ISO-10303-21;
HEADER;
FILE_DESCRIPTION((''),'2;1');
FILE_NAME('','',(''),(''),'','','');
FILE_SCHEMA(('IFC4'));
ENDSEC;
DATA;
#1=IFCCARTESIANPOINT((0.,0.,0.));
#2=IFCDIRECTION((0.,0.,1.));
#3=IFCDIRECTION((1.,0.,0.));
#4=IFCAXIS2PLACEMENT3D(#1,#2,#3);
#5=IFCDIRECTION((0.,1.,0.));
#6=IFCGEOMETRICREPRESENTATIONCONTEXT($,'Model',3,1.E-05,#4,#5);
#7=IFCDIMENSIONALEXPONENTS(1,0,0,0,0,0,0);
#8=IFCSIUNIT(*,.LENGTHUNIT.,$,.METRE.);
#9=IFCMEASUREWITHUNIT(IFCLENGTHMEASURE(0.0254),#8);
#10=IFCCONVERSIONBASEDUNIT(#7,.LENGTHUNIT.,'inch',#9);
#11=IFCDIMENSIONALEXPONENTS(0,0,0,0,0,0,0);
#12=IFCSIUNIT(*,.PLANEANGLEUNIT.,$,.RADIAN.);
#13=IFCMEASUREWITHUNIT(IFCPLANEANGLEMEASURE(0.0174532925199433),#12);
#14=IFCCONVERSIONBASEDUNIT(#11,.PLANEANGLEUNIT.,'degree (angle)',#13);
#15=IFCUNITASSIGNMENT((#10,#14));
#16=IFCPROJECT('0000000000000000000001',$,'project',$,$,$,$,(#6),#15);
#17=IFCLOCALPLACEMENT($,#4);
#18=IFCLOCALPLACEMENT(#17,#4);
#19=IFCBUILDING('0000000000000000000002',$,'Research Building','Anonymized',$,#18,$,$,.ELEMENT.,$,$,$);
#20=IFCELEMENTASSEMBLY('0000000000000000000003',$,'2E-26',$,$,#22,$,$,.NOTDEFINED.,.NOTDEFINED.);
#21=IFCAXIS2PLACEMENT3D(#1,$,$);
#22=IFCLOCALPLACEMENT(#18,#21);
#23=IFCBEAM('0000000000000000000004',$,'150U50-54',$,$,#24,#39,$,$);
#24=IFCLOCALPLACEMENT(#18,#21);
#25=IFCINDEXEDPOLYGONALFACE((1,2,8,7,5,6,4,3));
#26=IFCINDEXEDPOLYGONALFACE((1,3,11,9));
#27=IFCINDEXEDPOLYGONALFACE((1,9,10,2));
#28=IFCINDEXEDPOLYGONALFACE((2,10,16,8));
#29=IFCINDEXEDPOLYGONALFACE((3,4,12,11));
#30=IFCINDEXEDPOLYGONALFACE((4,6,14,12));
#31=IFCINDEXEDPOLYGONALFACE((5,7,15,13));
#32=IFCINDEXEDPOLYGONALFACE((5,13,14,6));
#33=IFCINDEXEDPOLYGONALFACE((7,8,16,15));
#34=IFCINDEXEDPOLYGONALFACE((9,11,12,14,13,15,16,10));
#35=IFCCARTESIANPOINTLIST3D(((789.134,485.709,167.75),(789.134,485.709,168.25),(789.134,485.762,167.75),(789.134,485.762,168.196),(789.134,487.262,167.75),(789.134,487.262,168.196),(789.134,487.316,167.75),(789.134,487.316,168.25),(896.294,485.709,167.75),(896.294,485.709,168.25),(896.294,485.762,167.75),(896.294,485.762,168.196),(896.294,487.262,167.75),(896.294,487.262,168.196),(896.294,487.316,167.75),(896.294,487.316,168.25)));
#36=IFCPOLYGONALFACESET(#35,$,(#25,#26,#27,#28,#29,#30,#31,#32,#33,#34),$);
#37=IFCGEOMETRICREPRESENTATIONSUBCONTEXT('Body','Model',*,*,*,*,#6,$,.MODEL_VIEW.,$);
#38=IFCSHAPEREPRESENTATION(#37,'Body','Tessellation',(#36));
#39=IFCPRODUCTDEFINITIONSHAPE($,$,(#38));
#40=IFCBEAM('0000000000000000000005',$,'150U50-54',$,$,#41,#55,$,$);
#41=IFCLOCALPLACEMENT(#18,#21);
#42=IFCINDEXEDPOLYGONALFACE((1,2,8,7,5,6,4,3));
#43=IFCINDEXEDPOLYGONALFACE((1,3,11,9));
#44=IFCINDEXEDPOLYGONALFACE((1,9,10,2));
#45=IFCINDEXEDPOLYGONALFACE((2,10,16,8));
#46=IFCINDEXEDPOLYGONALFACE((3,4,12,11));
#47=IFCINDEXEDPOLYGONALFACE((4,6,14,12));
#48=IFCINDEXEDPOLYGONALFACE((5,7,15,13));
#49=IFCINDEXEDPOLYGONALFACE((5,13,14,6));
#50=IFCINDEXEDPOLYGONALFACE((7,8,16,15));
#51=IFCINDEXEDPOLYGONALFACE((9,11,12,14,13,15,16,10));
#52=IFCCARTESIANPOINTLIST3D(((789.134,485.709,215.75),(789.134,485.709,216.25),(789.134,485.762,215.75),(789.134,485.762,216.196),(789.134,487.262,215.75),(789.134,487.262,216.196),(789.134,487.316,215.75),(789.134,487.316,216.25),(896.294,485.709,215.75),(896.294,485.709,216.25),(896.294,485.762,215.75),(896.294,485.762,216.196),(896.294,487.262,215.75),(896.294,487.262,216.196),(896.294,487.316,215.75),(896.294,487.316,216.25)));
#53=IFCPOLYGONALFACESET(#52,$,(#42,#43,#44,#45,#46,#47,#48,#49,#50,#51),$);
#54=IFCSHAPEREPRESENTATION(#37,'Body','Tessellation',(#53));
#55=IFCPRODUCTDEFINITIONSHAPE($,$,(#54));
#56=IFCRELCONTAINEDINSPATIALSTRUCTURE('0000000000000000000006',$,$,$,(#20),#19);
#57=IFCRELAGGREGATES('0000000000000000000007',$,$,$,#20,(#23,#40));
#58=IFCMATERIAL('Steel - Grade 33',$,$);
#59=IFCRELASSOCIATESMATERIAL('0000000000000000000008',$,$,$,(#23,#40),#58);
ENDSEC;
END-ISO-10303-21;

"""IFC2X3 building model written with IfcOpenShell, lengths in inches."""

from ifc_helpers import new_model, entity, si_unit, converted_unit, direction, frame, origin_with_axes, place, context, subcontext, project, spatial, polyline, segment, composite_curve, outline, extrude, material, element, aggregate, save


model = new_model("IFC2X3")

# Units and contexts
model_context = context("Model", 3, precision=1e-05, world=origin_with_axes(), true_north=direction((0.0, 1.0, 0.0)))
body_context = subcontext(model_context, "Body", "Model", "MODEL_VIEW")
ifc_project = project(units=[converted_unit("LENGTHUNIT", "inch", entity("IfcLengthMeasure", 0.0254), si_unit("LENGTHUNIT", "METRE"), dimensions=[1, 0, 0, 0, 0, 0, 0]), converted_unit("PLANEANGLEUNIT", "degree (angle)", entity("IfcPlaneAngleMeasure", 0.0174532925199433), si_unit("PLANEANGLEUNIT", "RADIAN"), dimensions=[0, 0, 0, 0, 0, 0, 0])], contexts=[model_context])

# Building
placement = place(None, origin_with_axes())
building_placement = place(placement, origin_with_axes())
building = spatial("IfcBuilding", at=building_placement, Name="Research Building", Description="Anonymized", CompositionType="ELEMENT")

# Element assembly, beams
assembly_placement = place(building_placement, origin_with_axes())
assembly = element("IfcElementAssembly", 1, at=assembly_placement, inside=building, Name="2E-26", AssemblyPlace="NOTDEFINED", PredefinedType="NOTDEFINED")
ifc_material = material(Name="Steel - Grade 33")
beam_1_placement = place(assembly_placement, frame((789.134, 486.512, 168.0), z_axis=(1.0, 0.0, 0.0), x_axis=(0.0, 0.0, -1.0)))
beam_1 = element("IfcBeam", 2, at=beam_1_placement, material=ifc_material, Name="150U50-54", context=body_context, shape_type="SweptSolid", body=[
    extrude(outline(composite_curve([segment(polyline([(-0.25, -0.804), (-0.25, 0.804), (0.25, 0.804), (0.25, 0.75), (-0.196, 0.75), (-0.196, -0.75), (0.25, -0.75), (0.25, -0.804), (-0.25, -0.804)]), True, "CONTINUOUS")], self_intersect=False)), origin_with_axes(), (0.0, 0.0, 1.0), 107.16),
])
beam_2_placement = place(assembly_placement, frame((789.134, 486.512, 216.0), z_axis=(1.0, 0.0, 0.0), x_axis=(0.0, 0.0, -1.0)))
beam_2 = element("IfcBeam", 3, at=beam_2_placement, material=ifc_material, Name="150U50-54", context=body_context, shape_type="SweptSolid", body=[
    extrude(outline(composite_curve([segment(polyline([(-0.25, -0.804), (-0.25, 0.804), (0.25, 0.804), (0.25, 0.75), (-0.196, 0.75), (-0.196, -0.75), (0.25, -0.75), (0.25, -0.804), (-0.25, -0.804)]), True, "CONTINUOUS")], self_intersect=False)), origin_with_axes(), (0.0, 0.0, 1.0), 107.16),
])
aggregate(assembly, [beam_1, beam_2])

save(model, "model.ifc")
